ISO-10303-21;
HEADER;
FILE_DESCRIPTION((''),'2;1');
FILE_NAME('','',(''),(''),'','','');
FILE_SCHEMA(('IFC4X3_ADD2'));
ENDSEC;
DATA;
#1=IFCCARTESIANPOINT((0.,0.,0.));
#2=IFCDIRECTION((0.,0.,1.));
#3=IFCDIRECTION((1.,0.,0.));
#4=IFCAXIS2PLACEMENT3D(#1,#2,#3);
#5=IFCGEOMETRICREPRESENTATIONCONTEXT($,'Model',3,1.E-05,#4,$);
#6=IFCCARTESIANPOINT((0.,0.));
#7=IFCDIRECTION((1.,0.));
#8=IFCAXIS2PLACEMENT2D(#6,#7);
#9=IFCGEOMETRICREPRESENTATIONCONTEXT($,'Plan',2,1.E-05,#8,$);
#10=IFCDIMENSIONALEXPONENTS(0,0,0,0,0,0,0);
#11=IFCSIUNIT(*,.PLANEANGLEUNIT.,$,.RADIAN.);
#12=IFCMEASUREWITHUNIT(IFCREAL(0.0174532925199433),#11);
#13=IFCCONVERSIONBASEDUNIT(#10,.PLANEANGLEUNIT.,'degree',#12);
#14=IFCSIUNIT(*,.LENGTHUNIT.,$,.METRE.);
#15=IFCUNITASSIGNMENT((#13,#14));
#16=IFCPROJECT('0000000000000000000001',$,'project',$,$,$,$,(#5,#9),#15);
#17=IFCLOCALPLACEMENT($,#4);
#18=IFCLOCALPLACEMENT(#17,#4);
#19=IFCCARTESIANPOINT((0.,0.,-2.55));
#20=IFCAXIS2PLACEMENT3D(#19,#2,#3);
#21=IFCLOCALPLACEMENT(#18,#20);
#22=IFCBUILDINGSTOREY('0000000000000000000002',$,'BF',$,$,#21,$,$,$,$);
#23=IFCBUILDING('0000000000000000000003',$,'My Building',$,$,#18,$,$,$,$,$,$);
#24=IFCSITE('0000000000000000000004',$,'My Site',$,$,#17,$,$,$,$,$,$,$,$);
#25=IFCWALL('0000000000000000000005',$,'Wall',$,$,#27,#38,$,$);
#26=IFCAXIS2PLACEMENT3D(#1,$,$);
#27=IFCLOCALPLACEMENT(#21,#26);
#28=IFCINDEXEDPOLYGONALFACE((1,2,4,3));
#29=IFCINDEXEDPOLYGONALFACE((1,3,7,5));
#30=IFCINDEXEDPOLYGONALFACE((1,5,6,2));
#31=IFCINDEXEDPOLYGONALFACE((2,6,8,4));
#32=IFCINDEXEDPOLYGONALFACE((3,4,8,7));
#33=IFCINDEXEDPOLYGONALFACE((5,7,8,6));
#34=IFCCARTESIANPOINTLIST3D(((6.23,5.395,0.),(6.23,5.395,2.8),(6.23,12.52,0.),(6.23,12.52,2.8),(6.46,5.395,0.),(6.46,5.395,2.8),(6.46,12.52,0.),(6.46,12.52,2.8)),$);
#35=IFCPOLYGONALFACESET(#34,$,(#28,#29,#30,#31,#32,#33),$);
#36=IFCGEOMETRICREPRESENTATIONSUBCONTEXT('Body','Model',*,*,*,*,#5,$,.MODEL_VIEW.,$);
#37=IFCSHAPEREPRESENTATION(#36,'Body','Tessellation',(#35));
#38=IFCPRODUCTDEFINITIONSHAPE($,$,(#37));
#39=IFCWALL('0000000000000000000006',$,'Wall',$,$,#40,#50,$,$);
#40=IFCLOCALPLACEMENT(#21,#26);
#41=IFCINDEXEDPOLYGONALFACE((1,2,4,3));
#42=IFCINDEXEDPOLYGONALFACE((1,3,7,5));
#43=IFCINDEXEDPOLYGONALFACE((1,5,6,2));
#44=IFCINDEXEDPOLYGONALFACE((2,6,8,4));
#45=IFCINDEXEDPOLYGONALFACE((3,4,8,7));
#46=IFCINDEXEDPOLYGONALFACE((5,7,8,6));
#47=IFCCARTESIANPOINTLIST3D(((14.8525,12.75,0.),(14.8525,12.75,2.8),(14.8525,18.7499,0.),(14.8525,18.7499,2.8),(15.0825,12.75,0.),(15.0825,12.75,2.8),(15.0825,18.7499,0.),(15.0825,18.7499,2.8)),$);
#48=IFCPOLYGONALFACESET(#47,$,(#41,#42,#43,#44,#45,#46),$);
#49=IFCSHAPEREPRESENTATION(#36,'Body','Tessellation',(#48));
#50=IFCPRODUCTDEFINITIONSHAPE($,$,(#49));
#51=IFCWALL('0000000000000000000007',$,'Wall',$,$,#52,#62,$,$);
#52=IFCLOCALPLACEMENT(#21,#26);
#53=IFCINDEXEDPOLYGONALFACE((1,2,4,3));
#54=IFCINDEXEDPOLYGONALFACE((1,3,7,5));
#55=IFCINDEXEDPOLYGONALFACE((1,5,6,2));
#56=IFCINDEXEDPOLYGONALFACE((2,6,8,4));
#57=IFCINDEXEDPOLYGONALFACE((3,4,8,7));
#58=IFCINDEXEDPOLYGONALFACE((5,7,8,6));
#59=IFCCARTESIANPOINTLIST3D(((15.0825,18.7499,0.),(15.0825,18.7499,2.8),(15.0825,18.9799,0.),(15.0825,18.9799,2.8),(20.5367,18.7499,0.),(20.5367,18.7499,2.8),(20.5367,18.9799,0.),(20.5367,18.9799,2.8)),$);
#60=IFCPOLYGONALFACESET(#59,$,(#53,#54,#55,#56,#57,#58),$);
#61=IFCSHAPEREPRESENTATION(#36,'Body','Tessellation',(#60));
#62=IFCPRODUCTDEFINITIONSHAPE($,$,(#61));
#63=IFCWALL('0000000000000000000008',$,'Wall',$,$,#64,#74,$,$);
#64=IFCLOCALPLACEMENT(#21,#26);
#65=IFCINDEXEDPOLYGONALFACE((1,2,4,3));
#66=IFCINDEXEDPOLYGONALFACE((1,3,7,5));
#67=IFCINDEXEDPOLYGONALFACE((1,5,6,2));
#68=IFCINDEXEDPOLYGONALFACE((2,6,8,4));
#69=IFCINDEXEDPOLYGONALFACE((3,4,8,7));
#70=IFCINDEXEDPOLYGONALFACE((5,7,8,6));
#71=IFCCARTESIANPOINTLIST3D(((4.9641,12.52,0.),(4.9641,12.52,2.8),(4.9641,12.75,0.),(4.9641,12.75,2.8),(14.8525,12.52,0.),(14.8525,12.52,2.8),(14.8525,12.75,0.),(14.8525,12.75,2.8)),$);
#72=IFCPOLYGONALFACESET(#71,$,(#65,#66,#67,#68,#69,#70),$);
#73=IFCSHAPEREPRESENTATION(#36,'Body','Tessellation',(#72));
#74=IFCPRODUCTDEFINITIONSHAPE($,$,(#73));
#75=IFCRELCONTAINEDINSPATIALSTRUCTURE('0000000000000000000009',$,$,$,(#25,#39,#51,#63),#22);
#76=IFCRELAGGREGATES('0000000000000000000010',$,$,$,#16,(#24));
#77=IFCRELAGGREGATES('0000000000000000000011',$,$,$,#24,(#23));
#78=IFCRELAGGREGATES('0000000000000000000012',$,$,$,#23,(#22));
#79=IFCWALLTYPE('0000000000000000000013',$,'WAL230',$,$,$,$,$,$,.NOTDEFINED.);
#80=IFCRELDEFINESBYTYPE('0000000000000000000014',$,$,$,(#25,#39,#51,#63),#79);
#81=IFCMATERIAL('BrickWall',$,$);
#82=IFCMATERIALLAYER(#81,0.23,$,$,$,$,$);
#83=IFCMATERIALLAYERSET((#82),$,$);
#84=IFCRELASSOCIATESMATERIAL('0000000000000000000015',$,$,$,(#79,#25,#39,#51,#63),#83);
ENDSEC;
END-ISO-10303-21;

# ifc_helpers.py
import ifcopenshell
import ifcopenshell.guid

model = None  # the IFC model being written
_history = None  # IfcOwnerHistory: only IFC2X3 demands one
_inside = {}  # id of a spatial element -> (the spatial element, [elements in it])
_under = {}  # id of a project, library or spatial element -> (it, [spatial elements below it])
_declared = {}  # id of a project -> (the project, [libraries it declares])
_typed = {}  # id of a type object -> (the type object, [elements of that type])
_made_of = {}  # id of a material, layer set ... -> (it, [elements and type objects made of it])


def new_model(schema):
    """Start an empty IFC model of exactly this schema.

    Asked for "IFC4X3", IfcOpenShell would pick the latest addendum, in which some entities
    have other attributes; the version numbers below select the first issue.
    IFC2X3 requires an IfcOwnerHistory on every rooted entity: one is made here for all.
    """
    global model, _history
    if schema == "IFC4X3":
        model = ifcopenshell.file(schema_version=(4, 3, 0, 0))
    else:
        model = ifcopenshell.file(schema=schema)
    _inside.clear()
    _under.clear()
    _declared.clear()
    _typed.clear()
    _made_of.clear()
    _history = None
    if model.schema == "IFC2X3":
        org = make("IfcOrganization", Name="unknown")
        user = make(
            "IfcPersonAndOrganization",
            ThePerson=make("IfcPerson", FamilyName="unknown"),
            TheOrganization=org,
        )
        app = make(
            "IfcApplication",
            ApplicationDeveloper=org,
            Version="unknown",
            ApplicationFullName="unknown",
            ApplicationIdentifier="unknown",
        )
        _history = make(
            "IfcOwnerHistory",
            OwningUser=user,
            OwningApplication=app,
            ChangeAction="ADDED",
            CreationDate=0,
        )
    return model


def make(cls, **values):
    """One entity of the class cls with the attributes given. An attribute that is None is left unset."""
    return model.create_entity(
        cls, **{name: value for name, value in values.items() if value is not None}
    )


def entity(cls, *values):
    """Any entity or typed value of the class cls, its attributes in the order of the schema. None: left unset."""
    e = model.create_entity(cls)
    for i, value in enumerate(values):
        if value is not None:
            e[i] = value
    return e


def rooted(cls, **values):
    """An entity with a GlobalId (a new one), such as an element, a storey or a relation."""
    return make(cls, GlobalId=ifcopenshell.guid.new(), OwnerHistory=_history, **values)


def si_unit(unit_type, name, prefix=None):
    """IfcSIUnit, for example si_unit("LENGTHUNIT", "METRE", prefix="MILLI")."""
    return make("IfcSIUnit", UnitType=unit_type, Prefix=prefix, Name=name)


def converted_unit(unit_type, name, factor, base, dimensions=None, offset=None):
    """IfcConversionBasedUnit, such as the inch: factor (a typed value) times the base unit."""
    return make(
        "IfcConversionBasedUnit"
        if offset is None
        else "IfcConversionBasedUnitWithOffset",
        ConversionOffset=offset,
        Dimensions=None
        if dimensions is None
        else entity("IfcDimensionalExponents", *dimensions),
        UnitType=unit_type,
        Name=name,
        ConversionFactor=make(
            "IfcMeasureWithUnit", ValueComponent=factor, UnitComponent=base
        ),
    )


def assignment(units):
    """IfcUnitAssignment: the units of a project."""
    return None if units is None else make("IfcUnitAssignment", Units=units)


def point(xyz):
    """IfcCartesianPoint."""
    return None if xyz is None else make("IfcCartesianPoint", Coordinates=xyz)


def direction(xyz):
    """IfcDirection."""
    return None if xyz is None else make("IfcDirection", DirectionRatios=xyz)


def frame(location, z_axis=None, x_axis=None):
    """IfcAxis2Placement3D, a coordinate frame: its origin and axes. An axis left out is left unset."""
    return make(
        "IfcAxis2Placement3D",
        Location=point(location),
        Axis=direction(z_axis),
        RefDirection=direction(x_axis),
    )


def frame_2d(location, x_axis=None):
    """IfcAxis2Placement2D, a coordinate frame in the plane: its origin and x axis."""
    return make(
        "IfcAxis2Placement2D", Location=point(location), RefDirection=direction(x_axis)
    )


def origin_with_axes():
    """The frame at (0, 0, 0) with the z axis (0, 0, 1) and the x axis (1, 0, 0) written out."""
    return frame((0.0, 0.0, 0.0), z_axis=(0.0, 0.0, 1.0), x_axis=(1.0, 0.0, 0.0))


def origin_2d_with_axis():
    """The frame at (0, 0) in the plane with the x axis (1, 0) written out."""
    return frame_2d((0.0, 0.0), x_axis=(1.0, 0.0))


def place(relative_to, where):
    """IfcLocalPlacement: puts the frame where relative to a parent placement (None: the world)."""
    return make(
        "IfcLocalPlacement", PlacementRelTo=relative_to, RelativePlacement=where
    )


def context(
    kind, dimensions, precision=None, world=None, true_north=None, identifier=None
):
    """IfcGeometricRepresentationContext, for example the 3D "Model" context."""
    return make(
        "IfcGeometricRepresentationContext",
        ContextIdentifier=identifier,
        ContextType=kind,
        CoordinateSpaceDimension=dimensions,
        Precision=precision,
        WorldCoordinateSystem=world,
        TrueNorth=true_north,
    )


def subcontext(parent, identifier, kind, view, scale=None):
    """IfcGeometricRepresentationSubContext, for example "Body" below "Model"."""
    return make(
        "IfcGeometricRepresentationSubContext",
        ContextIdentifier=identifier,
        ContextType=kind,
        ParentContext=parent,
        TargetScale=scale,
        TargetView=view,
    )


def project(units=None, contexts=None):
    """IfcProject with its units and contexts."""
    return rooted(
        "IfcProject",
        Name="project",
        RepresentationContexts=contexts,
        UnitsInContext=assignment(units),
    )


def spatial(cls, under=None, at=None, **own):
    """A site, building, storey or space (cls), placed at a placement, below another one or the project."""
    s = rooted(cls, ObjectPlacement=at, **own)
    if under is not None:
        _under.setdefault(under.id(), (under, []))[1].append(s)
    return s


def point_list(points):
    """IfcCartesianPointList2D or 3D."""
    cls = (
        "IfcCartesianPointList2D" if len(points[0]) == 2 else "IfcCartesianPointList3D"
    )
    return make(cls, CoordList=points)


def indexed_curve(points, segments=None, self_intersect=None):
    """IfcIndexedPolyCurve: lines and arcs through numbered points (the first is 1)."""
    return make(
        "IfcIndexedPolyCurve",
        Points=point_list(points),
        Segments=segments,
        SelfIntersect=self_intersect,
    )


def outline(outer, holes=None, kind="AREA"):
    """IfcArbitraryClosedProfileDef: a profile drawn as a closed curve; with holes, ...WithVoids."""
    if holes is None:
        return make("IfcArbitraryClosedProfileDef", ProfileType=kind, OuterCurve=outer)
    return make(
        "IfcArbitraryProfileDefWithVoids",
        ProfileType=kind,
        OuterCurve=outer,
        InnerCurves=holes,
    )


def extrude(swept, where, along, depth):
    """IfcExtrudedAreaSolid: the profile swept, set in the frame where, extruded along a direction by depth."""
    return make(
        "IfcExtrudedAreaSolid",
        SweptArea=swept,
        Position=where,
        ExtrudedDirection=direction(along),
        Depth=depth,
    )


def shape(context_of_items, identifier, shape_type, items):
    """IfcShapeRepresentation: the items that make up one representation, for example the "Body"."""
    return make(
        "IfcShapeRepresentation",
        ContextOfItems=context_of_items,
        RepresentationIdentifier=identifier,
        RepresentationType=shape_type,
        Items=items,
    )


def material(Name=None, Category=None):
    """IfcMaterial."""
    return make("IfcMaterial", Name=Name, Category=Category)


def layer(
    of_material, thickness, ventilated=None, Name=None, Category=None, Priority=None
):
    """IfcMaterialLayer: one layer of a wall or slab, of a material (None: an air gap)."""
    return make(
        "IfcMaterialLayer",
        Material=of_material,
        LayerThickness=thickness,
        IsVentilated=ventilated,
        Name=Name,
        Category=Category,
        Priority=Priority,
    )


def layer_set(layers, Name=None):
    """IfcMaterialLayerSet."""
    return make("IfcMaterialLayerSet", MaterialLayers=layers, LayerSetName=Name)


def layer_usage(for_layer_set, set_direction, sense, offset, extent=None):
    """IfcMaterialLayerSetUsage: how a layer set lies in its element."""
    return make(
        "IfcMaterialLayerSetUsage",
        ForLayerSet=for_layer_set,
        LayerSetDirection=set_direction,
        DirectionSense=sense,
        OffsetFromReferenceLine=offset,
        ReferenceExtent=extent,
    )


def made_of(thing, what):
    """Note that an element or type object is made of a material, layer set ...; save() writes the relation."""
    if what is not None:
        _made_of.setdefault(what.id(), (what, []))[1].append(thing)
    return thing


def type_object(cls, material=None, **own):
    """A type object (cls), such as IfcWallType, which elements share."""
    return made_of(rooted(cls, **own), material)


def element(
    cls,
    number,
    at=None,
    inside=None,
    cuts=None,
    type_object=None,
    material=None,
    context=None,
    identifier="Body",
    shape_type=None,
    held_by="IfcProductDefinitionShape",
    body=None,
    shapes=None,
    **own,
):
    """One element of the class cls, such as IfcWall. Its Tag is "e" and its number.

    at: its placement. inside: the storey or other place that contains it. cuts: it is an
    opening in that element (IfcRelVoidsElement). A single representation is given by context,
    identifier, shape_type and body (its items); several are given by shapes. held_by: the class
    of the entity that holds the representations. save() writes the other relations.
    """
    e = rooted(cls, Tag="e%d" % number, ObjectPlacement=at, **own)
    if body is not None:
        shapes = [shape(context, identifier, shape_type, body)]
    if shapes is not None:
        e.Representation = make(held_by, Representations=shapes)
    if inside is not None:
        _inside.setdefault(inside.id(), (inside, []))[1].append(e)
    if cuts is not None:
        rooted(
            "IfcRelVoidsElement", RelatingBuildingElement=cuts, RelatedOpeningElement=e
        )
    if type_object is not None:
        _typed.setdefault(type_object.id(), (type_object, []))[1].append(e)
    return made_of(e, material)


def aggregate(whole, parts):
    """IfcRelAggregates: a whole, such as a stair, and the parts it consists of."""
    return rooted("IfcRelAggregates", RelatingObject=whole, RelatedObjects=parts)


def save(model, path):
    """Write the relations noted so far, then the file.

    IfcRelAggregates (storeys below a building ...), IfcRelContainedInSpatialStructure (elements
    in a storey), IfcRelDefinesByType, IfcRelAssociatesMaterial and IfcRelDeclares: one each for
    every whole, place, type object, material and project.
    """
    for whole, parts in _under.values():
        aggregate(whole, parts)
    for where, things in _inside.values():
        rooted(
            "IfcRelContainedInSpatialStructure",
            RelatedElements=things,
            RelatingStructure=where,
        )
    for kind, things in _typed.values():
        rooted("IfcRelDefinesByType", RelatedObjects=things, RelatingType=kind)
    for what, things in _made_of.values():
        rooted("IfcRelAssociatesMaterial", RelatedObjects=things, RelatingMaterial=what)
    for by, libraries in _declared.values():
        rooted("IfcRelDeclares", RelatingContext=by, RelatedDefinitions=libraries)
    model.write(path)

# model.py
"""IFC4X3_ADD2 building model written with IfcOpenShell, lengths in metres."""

from ifc_helpers import new_model, entity, si_unit, converted_unit, frame, origin_with_axes, origin_2d_with_axis, place, context, subcontext, project, spatial, indexed_curve, outline, extrude, material, layer, layer_set, layer_usage, type_object, element, save


model = new_model("IFC4X3_ADD2")

# Units and contexts
model_context = context("Model", 3, precision=1e-05, world=origin_with_axes())
plan_context = context("Plan", 2, precision=1e-05, world=origin_2d_with_axis())
body_context_1 = subcontext(model_context, "Body", "Model", "MODEL_VIEW")
ifc_project = project(units=[converted_unit("PLANEANGLEUNIT", "degree", entity("IfcReal", 0.0174532925199433), si_unit("PLANEANGLEUNIT", "RADIAN"), dimensions=[0, 0, 0, 0, 0, 0, 0]), si_unit("LENGTHUNIT", "METRE")], contexts=[model_context, plan_context])

# Site, building, storey
site_placement = place(None, origin_with_axes())
site = spatial("IfcSite", under=ifc_project, at=site_placement, Name="My Site")
building_placement = place(site_placement, origin_with_axes())
building = spatial("IfcBuilding", under=site, at=building_placement, Name="My Building")
storey_placement = place(building_placement, frame((0.0, 0.0, -2.55), z_axis=(0.0, 0.0, 1.0), x_axis=(1.0, 0.0, 0.0)))
storey = spatial("IfcBuildingStorey", under=building, at=storey_placement, Name="BF")

# Walls
ifc_material_1 = material(Name="BrickWall")
ifc_layer = layer(ifc_material_1, 0.23)
ifc_layer_set = layer_set([ifc_layer])
ifc_layer_usage_1 = layer_usage(ifc_layer_set, "AXIS2", "POSITIVE", 0.0)
wall_type = type_object("IfcWallType", Name="WAL230", PredefinedType="NOTDEFINED", material=ifc_layer_set)
wall_1_placement = place(storey_placement, frame((6.46, 5.395, 0.0), z_axis=(0.0, 0.0, 1.0), x_axis=(0.0, 1.0, 0.0)))
element("IfcWall", 1, at=wall_1_placement, inside=storey, type_object=wall_type, material=ifc_layer_usage_1, Name="Wall", context=body_context_1, shape_type="SweptSolid", body=[
    extrude(outline(indexed_curve([(0.0, 0.0), (0.0, 0.23), (7.125, 0.23), (7.125, 0.0), (0.0, 0.0)], self_intersect=False)), origin_with_axes(), (0.0, 0.0, 1.0), 2.8),
])
ifc_layer_usage_2 = layer_usage(ifc_layer_set, "AXIS2", "POSITIVE", 0.0)
wall_2_placement = place(storey_placement, frame((15.0825, 12.75, 0.0), z_axis=(0.0, 0.0, 1.0), x_axis=(0.0, 1.0, 0.0)))
element("IfcWall", 2, at=wall_2_placement, inside=storey, type_object=wall_type, material=ifc_layer_usage_2, Name="Wall", context=body_context_1, shape_type="SweptSolid", body=[
    extrude(outline(indexed_curve([(0.0, 0.0), (0.0, 0.23), (5.9999, 0.23), (5.9999, 0.0), (0.0, 0.0)], self_intersect=False)), origin_with_axes(), (0.0, 0.0, 1.0), 2.8),
])
ifc_layer_usage_3 = layer_usage(ifc_layer_set, "AXIS2", "POSITIVE", 0.0)
wall_3_placement = place(storey_placement, frame((15.0825, 18.7499, 0.0), z_axis=(0.0, 0.0, 1.0), x_axis=(1.0, 0.0, 0.0)))
element("IfcWall", 3, at=wall_3_placement, inside=storey, type_object=wall_type, material=ifc_layer_usage_3, Name="Wall", context=body_context_1, shape_type="SweptSolid", body=[
    extrude(outline(indexed_curve([(0.0, 0.0), (0.0, 0.23), (5.4543, 0.23), (5.4543, 0.0), (0.0, 0.0)], self_intersect=False)), origin_with_axes(), (0.0, 0.0, 1.0), 2.8),
])
ifc_layer_usage_4 = layer_usage(ifc_layer_set, "AXIS2", "POSITIVE", 0.0)
wall_4_placement = place(storey_placement, frame((4.9641, 12.52, 0.0), z_axis=(0.0, 0.0, 1.0), x_axis=(1.0, 0.0, 0.0)))
element("IfcWall", 4, at=wall_4_placement, inside=storey, type_object=wall_type, material=ifc_layer_usage_4, Name="Wall", context=body_context_1, shape_type="SweptSolid", body=[
    extrude(outline(indexed_curve([(0.0, 0.0), (0.0, 0.23), (9.8884, 0.23), (9.8884, 0.0), (0.0, 0.0)], self_intersect=False)), origin_with_axes(), (0.0, 0.0, 1.0), 2.8),
])

save(model, "model.ifc")
